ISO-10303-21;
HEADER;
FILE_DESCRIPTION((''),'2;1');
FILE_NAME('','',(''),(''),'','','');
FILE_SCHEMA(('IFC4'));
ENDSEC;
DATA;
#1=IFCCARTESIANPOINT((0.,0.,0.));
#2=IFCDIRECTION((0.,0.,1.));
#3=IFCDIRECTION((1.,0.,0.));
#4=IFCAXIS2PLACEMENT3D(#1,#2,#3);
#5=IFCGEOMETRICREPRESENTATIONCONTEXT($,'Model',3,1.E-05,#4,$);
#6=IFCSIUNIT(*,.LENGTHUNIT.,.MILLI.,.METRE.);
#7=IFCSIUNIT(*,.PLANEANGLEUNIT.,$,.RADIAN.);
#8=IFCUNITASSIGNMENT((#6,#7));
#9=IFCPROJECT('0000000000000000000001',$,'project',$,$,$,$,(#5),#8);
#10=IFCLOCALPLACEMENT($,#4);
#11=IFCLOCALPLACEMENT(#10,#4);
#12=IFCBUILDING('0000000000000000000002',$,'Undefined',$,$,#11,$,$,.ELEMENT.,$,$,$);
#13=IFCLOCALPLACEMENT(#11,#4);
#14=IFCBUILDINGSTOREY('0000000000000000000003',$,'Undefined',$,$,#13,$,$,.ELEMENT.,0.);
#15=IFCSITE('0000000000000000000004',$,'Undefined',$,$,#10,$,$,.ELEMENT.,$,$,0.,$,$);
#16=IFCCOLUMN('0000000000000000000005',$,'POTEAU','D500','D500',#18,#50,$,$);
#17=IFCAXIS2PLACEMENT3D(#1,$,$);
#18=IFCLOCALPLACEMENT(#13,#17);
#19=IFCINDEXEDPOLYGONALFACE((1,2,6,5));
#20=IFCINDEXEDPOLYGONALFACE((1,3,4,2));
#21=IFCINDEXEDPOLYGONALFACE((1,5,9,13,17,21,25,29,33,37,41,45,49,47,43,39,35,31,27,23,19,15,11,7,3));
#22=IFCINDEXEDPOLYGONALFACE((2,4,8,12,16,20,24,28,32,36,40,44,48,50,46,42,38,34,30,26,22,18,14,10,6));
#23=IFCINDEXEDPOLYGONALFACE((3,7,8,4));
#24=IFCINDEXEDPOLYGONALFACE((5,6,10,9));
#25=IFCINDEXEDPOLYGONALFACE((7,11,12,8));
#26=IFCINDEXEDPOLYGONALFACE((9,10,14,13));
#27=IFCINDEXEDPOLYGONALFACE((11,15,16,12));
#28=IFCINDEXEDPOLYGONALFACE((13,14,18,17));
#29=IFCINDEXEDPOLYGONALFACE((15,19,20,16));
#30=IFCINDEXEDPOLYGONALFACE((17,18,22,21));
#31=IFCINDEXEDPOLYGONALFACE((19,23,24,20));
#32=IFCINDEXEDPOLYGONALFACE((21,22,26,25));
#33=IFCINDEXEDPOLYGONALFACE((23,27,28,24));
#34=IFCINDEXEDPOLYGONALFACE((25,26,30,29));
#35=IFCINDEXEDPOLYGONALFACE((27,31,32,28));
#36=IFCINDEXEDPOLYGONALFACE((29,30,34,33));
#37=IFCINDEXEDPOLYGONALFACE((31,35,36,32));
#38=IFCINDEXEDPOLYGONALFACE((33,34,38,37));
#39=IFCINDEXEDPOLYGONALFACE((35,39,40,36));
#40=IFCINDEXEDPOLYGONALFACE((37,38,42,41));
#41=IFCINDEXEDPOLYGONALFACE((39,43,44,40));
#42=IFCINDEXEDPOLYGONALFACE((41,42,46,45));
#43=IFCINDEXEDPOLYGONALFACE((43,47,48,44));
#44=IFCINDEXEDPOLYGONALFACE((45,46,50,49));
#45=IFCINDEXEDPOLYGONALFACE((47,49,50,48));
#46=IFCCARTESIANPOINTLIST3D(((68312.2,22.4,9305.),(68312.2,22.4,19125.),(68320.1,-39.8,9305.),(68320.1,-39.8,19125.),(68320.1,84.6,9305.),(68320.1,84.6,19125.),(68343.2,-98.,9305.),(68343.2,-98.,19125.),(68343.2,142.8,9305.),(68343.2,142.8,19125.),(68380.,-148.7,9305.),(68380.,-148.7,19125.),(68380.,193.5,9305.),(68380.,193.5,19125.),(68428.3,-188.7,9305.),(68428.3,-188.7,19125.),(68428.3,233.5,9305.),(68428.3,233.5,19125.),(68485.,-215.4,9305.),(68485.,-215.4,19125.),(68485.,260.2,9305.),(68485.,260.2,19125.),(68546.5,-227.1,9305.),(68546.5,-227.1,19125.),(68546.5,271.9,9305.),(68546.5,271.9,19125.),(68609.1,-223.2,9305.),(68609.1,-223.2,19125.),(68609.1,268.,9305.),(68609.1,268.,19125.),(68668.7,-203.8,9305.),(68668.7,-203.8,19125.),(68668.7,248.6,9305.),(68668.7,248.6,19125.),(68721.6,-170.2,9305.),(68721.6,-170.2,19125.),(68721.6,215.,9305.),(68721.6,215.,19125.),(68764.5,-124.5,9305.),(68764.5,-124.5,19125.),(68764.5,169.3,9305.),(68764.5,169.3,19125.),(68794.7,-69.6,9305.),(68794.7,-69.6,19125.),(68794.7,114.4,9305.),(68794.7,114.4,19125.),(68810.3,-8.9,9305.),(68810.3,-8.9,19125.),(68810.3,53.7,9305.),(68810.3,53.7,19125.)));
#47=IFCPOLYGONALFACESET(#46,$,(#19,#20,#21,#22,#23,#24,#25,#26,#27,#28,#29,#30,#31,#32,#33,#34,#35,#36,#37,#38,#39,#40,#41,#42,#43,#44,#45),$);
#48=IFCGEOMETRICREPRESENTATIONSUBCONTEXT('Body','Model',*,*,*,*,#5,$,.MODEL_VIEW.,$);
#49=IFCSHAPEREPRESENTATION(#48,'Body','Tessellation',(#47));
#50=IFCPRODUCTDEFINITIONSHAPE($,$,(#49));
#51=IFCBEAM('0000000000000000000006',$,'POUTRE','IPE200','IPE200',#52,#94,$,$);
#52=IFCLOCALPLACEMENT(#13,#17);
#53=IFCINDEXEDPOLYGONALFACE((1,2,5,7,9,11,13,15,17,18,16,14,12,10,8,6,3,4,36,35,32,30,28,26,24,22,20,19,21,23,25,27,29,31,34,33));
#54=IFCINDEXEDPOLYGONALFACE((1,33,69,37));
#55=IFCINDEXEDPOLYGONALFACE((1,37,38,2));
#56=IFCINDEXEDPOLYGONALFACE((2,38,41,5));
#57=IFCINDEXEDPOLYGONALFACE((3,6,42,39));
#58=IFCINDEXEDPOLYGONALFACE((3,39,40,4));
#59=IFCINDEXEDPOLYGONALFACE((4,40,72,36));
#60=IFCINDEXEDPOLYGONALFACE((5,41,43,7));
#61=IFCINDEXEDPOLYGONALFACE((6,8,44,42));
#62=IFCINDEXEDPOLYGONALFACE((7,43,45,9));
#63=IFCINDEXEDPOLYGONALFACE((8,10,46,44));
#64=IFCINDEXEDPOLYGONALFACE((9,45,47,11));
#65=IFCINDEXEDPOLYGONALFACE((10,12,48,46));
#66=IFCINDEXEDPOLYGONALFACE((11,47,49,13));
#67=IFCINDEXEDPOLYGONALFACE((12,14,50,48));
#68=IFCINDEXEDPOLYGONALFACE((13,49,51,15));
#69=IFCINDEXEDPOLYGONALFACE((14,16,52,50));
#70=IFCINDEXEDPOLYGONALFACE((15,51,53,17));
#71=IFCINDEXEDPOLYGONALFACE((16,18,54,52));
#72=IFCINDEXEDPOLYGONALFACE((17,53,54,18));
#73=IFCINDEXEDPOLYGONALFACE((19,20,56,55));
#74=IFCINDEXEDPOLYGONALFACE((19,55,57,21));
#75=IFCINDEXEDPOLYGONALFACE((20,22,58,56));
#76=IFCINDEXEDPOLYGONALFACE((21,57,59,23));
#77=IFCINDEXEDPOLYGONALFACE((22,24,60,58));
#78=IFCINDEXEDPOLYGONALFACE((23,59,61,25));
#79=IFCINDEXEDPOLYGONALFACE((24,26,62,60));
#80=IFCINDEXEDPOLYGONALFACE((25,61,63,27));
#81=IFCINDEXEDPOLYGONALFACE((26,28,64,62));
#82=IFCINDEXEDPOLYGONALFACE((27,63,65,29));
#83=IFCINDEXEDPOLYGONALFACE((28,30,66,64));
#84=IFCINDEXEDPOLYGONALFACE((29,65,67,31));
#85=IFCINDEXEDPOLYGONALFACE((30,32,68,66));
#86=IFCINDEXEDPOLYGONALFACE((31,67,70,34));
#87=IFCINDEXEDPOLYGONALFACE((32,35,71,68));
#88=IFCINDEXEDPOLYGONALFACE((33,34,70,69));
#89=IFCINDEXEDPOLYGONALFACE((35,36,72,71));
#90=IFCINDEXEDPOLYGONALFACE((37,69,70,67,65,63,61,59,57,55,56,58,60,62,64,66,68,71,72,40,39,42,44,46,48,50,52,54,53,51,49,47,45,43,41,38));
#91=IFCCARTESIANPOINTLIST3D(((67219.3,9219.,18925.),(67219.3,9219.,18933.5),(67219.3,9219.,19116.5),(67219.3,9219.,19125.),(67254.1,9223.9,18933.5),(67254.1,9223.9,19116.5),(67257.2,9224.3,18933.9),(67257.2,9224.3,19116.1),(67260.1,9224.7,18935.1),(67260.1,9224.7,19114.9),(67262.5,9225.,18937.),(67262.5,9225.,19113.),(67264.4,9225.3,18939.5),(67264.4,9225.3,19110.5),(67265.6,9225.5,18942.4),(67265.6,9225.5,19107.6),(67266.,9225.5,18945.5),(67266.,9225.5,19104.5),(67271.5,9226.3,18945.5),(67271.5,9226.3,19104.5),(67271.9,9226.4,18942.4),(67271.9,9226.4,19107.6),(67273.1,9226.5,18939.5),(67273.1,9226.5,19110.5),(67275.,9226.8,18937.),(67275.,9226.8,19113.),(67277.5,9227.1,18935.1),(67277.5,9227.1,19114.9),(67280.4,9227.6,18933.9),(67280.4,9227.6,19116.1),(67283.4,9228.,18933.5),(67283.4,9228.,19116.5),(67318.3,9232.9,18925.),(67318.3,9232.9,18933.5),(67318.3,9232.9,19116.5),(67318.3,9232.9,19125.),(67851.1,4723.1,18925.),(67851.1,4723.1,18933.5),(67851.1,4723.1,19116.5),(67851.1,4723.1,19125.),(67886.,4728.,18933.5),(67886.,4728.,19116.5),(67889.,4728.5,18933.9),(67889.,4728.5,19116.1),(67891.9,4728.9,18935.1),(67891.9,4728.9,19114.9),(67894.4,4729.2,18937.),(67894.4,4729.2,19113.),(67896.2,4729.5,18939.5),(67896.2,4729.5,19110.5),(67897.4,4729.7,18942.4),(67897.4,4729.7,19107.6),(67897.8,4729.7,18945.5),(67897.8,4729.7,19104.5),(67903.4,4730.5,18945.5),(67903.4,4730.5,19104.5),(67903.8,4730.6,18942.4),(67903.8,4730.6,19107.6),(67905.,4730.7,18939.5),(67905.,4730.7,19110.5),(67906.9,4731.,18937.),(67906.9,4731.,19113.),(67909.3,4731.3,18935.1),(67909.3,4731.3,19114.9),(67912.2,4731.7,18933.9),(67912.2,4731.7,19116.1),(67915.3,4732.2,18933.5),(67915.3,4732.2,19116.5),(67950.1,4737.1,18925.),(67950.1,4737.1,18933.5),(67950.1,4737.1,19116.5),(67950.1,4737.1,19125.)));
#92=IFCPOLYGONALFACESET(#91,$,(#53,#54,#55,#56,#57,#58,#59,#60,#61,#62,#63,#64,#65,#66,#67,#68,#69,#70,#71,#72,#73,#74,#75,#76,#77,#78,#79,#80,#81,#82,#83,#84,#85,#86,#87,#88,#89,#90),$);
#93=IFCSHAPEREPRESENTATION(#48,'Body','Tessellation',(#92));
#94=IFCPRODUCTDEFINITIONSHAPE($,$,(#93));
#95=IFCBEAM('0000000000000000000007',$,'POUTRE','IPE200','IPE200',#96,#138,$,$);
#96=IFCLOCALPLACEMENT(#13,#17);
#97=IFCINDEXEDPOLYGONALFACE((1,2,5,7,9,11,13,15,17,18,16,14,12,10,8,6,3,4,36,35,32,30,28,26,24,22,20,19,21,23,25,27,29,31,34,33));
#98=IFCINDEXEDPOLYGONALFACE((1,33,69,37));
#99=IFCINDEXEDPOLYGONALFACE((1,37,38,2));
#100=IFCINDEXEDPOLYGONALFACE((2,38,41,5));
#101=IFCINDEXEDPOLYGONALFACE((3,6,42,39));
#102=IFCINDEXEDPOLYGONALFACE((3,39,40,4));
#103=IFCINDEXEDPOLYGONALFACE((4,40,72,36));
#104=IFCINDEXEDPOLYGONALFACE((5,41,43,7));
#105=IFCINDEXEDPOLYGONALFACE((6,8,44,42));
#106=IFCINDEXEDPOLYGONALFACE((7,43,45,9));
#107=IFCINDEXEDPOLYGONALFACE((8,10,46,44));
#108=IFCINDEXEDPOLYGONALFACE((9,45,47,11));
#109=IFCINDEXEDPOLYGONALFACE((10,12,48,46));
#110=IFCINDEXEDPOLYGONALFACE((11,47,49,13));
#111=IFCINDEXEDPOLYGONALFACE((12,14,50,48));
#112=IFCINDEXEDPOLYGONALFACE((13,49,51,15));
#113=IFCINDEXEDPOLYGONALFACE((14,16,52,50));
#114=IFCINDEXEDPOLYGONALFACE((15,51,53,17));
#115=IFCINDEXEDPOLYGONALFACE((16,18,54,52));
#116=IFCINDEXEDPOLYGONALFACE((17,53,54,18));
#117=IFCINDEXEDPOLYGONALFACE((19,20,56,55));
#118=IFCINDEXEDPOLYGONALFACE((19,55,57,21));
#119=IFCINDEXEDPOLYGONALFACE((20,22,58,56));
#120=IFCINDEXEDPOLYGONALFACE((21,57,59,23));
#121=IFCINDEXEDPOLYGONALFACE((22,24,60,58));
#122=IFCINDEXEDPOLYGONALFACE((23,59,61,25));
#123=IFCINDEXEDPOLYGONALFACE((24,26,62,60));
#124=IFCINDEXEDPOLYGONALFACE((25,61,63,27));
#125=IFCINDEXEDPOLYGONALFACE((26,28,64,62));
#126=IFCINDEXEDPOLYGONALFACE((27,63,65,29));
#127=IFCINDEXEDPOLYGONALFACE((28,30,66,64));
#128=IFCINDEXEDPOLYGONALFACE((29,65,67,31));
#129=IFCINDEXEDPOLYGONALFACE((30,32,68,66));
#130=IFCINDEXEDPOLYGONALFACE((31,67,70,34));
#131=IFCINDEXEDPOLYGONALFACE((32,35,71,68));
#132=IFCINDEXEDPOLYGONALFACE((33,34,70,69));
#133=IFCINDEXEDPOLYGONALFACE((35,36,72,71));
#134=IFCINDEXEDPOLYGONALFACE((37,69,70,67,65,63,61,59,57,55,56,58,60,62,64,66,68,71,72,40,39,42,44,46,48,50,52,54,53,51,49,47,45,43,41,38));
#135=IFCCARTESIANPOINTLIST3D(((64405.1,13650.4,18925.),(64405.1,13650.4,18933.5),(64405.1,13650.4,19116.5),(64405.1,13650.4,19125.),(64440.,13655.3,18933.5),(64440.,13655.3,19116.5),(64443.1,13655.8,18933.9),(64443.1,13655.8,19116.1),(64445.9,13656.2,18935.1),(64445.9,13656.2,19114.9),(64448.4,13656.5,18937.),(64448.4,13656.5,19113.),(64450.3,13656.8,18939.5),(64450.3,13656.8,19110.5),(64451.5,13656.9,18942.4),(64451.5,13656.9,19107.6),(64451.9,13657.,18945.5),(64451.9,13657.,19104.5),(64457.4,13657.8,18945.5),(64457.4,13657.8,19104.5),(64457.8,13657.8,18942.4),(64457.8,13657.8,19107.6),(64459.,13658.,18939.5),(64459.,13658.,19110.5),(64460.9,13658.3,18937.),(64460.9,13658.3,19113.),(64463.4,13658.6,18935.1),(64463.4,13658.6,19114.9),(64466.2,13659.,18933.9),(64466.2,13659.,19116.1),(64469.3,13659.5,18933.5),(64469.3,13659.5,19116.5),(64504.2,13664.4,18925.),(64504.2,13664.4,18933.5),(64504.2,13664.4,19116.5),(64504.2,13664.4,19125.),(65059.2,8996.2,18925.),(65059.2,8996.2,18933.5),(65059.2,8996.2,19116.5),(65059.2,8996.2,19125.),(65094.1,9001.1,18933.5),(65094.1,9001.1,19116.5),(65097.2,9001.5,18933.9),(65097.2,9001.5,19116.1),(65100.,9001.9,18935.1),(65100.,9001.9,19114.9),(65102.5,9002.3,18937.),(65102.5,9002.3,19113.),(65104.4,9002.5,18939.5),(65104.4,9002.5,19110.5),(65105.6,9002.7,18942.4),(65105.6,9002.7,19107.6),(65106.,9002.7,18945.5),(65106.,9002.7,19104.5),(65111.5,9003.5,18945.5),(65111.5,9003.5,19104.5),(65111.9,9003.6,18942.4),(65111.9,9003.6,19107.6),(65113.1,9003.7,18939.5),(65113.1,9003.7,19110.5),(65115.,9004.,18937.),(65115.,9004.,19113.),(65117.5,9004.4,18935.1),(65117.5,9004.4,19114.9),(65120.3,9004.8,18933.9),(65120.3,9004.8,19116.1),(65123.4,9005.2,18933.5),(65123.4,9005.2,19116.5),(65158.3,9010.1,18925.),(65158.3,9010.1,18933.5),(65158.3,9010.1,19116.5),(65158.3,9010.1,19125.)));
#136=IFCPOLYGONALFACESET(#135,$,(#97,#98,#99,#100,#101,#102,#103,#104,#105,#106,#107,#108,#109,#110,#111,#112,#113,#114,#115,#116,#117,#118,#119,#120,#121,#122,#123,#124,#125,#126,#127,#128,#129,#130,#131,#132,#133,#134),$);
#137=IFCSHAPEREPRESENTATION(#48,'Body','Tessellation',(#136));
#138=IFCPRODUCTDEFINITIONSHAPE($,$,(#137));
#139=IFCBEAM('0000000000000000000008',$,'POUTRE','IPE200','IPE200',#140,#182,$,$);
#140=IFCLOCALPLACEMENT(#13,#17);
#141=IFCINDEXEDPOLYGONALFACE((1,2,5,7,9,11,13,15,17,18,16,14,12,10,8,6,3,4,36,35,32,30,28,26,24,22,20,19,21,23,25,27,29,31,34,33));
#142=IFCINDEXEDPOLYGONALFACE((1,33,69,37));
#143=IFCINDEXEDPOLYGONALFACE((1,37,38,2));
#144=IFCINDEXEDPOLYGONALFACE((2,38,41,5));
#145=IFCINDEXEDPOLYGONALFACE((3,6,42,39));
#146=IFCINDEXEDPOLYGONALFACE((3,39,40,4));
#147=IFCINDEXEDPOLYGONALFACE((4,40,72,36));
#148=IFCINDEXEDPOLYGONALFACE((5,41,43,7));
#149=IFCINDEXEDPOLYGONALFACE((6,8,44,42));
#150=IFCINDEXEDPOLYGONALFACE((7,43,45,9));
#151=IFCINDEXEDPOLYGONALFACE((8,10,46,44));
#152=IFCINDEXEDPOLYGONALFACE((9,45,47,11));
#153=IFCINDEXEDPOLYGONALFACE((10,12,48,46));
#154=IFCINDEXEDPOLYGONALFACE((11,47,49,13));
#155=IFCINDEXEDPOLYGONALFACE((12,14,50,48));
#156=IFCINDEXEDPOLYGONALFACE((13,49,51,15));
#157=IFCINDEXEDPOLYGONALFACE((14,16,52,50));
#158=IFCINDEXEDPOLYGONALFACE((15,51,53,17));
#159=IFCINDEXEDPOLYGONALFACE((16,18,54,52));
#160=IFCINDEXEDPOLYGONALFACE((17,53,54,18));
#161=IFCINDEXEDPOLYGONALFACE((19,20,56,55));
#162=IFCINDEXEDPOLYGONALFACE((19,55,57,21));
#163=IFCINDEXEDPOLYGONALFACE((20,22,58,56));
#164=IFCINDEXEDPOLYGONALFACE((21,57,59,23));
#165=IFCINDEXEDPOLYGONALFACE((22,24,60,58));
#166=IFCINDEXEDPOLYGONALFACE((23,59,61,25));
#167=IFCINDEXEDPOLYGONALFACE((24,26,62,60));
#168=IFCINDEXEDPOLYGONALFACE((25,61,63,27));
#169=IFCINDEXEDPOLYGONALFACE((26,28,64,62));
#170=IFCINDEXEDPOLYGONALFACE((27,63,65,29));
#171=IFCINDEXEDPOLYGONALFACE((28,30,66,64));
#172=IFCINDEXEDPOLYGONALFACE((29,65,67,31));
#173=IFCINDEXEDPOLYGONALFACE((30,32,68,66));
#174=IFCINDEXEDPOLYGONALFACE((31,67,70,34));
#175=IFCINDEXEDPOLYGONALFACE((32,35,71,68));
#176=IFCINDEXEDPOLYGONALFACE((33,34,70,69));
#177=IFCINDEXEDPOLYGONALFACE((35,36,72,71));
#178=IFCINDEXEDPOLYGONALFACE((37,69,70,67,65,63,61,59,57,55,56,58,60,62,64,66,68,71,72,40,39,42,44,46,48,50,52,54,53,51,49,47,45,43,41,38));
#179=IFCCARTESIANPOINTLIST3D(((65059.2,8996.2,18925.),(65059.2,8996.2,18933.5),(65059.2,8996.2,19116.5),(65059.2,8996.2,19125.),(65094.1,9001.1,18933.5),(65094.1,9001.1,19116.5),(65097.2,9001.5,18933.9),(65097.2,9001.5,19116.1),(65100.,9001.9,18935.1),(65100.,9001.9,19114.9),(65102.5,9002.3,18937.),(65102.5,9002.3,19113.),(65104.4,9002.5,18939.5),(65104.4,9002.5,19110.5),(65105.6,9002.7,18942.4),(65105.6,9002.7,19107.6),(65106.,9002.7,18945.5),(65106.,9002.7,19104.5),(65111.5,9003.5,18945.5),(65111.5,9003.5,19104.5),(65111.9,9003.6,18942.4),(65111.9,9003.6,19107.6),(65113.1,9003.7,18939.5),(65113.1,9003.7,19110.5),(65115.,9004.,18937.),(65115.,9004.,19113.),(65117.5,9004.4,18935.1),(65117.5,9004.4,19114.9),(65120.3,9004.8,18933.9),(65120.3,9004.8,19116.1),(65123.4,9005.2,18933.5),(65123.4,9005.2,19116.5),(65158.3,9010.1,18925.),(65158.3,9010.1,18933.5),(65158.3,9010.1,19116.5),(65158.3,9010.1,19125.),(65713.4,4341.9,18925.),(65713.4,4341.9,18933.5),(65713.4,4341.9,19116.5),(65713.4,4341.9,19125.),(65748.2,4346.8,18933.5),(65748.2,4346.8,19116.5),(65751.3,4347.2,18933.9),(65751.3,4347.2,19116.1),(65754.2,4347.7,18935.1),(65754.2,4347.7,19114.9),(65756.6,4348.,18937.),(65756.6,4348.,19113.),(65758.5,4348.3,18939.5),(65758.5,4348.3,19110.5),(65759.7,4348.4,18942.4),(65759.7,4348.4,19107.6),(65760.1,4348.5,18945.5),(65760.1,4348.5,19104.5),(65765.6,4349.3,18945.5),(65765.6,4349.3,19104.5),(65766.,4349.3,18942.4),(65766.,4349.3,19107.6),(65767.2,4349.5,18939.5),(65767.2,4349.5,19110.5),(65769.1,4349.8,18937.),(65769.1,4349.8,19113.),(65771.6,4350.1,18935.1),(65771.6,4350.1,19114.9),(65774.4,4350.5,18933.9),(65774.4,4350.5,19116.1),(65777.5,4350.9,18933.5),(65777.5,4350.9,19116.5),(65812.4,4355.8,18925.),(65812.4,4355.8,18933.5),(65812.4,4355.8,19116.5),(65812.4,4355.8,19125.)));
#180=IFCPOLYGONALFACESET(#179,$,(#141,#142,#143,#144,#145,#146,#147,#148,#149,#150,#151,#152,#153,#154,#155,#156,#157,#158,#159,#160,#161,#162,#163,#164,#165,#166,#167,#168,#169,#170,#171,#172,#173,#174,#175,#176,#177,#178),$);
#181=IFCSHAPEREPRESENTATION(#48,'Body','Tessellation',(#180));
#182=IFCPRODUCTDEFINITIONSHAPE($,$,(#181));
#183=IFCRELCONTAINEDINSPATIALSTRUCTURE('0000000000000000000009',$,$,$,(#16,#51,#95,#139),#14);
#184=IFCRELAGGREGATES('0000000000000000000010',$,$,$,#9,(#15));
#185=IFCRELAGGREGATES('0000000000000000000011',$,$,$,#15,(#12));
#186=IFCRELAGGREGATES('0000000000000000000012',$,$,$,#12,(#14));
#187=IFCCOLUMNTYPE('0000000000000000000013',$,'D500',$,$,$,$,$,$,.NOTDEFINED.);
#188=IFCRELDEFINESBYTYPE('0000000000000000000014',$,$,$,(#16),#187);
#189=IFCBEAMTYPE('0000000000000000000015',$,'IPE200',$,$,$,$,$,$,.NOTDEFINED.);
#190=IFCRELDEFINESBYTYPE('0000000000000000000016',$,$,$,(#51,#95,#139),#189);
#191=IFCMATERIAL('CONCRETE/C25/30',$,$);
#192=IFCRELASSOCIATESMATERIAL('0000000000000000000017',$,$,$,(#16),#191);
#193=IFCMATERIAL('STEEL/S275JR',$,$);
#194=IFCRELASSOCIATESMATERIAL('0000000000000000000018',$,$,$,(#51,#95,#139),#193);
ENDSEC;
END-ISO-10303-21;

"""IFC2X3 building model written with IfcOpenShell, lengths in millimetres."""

from ifc_helpers import new_model, si_unit, frame, origin_with_axes, origin_2d_with_axis, place, context, subcontext, project, spatial, circle, i_section, extrude, material, type_object, element, save


model = new_model("IFC2X3")

# Units and contexts
model_context = context("Model", 3, precision=1e-05, world=origin_with_axes())
body_context = subcontext(model_context, "Body", "Model", "MODEL_VIEW")
ifc_project = project(units=[si_unit("LENGTHUNIT", "METRE", prefix="MILLI"), si_unit("PLANEANGLEUNIT", "RADIAN")], contexts=[model_context])

# Site, building, storey
site_placement = place(None, origin_with_axes())
site = spatial("IfcSite", under=ifc_project, at=site_placement, Name="Undefined", CompositionType="ELEMENT", RefElevation=0.0)
building_placement = place(site_placement, origin_with_axes())
building = spatial("IfcBuilding", under=site, at=building_placement, Name="Undefined", CompositionType="ELEMENT")
storey_placement = place(building_placement, origin_with_axes())
storey = spatial("IfcBuildingStorey", under=building, at=storey_placement, Name="Undefined", CompositionType="ELEMENT", Elevation=0.0)

# Column
ifc_material_1 = material(Name="CONCRETE/C25/30")
ifc_material_2 = material(Name="STEEL/S275JR")
column_type_1 = type_object("IfcColumnType", Name="D500", PredefinedType="NOTDEFINED")
column_1_placement = place(storey_placement, frame((68562.2, 22.4, 9305.0), z_axis=(0.0, 0.0, 1.0), x_axis=(1.0, 0.0, 0.0)))
element("IfcColumn", 1, at=column_1_placement, inside=storey, type_object=column_type_1, material=ifc_material_1, Name="POTEAU", Description="D500", ObjectType="D500", context=body_context, shape_type="SweptSolid", body=[
    extrude(circle(Radius=250.0, at=origin_2d_with_axis()), frame((0.0, 0.0, 9820.0), z_axis=(0.0, 0.0, -1.0), x_axis=(-1.0, 0.0, 0.0)), (0.0, 0.0, 1.0), 9820.0),
])

# Beams
beam_type_1 = type_object("IfcBeamType", Name="IPE200", PredefinedType="NOTDEFINED")
beam_1_placement = place(storey_placement, frame((67911.7, 4650.9, 19025.0), z_axis=(0.0, 0.0, 1.0), x_axis=(-0.139172, 0.990268, 0.0)))
element("IfcBeam", 2, at=beam_1_placement, inside=storey, type_object=beam_type_1, material=ifc_material_2, Name="POUTRE", Description="IPE200", ObjectType="IPE200", context=body_context, shape_type="SweptSolid", body=[
    extrude(i_section(OverallWidth=100.0, OverallDepth=200.0, WebThickness=5.6, FlangeThickness=8.5, FilletRadius=12.0, at=origin_2d_with_axis()), frame((4620.0, 0.0, 0.0), z_axis=(-1.0, 0.0, 0.0), x_axis=(0.0, -1.0, 0.0)), (0.0, 0.0, 1.0), 4540.0),
])
for number, where, z_axis, x_axis, name in (
    (3, (65108.8, 9003.1, 19025.0), (0.0, 0.0, 1.0), (-0.139172, 0.990268, 0.0), "POUTRE"),
    (4, (65762.9, 4348.9, 19025.0), (0.0, 0.0, 1.0), (-0.139172, 0.990268, 0.0), "POUTRE"),
):
    element("IfcBeam", number, at=place(storey_placement, frame(where, z_axis=z_axis, x_axis=x_axis)), inside=storey, type_object=beam_type_1, material=ifc_material_2, Name=name, Description="IPE200", ObjectType="IPE200", context=body_context, shape_type="SweptSolid", body=[
        extrude(i_section(OverallWidth=100.0, OverallDepth=200.0, WebThickness=5.6, FlangeThickness=8.5, FilletRadius=12.0, at=origin_2d_with_axis()), frame((4700.0, 0.0, 0.0), z_axis=(-1.0, 0.0, 0.0), x_axis=(0.0, -1.0, 0.0)), (0.0, 0.0, 1.0), 4700.0),
    ])

save(model, "model.ifc")
